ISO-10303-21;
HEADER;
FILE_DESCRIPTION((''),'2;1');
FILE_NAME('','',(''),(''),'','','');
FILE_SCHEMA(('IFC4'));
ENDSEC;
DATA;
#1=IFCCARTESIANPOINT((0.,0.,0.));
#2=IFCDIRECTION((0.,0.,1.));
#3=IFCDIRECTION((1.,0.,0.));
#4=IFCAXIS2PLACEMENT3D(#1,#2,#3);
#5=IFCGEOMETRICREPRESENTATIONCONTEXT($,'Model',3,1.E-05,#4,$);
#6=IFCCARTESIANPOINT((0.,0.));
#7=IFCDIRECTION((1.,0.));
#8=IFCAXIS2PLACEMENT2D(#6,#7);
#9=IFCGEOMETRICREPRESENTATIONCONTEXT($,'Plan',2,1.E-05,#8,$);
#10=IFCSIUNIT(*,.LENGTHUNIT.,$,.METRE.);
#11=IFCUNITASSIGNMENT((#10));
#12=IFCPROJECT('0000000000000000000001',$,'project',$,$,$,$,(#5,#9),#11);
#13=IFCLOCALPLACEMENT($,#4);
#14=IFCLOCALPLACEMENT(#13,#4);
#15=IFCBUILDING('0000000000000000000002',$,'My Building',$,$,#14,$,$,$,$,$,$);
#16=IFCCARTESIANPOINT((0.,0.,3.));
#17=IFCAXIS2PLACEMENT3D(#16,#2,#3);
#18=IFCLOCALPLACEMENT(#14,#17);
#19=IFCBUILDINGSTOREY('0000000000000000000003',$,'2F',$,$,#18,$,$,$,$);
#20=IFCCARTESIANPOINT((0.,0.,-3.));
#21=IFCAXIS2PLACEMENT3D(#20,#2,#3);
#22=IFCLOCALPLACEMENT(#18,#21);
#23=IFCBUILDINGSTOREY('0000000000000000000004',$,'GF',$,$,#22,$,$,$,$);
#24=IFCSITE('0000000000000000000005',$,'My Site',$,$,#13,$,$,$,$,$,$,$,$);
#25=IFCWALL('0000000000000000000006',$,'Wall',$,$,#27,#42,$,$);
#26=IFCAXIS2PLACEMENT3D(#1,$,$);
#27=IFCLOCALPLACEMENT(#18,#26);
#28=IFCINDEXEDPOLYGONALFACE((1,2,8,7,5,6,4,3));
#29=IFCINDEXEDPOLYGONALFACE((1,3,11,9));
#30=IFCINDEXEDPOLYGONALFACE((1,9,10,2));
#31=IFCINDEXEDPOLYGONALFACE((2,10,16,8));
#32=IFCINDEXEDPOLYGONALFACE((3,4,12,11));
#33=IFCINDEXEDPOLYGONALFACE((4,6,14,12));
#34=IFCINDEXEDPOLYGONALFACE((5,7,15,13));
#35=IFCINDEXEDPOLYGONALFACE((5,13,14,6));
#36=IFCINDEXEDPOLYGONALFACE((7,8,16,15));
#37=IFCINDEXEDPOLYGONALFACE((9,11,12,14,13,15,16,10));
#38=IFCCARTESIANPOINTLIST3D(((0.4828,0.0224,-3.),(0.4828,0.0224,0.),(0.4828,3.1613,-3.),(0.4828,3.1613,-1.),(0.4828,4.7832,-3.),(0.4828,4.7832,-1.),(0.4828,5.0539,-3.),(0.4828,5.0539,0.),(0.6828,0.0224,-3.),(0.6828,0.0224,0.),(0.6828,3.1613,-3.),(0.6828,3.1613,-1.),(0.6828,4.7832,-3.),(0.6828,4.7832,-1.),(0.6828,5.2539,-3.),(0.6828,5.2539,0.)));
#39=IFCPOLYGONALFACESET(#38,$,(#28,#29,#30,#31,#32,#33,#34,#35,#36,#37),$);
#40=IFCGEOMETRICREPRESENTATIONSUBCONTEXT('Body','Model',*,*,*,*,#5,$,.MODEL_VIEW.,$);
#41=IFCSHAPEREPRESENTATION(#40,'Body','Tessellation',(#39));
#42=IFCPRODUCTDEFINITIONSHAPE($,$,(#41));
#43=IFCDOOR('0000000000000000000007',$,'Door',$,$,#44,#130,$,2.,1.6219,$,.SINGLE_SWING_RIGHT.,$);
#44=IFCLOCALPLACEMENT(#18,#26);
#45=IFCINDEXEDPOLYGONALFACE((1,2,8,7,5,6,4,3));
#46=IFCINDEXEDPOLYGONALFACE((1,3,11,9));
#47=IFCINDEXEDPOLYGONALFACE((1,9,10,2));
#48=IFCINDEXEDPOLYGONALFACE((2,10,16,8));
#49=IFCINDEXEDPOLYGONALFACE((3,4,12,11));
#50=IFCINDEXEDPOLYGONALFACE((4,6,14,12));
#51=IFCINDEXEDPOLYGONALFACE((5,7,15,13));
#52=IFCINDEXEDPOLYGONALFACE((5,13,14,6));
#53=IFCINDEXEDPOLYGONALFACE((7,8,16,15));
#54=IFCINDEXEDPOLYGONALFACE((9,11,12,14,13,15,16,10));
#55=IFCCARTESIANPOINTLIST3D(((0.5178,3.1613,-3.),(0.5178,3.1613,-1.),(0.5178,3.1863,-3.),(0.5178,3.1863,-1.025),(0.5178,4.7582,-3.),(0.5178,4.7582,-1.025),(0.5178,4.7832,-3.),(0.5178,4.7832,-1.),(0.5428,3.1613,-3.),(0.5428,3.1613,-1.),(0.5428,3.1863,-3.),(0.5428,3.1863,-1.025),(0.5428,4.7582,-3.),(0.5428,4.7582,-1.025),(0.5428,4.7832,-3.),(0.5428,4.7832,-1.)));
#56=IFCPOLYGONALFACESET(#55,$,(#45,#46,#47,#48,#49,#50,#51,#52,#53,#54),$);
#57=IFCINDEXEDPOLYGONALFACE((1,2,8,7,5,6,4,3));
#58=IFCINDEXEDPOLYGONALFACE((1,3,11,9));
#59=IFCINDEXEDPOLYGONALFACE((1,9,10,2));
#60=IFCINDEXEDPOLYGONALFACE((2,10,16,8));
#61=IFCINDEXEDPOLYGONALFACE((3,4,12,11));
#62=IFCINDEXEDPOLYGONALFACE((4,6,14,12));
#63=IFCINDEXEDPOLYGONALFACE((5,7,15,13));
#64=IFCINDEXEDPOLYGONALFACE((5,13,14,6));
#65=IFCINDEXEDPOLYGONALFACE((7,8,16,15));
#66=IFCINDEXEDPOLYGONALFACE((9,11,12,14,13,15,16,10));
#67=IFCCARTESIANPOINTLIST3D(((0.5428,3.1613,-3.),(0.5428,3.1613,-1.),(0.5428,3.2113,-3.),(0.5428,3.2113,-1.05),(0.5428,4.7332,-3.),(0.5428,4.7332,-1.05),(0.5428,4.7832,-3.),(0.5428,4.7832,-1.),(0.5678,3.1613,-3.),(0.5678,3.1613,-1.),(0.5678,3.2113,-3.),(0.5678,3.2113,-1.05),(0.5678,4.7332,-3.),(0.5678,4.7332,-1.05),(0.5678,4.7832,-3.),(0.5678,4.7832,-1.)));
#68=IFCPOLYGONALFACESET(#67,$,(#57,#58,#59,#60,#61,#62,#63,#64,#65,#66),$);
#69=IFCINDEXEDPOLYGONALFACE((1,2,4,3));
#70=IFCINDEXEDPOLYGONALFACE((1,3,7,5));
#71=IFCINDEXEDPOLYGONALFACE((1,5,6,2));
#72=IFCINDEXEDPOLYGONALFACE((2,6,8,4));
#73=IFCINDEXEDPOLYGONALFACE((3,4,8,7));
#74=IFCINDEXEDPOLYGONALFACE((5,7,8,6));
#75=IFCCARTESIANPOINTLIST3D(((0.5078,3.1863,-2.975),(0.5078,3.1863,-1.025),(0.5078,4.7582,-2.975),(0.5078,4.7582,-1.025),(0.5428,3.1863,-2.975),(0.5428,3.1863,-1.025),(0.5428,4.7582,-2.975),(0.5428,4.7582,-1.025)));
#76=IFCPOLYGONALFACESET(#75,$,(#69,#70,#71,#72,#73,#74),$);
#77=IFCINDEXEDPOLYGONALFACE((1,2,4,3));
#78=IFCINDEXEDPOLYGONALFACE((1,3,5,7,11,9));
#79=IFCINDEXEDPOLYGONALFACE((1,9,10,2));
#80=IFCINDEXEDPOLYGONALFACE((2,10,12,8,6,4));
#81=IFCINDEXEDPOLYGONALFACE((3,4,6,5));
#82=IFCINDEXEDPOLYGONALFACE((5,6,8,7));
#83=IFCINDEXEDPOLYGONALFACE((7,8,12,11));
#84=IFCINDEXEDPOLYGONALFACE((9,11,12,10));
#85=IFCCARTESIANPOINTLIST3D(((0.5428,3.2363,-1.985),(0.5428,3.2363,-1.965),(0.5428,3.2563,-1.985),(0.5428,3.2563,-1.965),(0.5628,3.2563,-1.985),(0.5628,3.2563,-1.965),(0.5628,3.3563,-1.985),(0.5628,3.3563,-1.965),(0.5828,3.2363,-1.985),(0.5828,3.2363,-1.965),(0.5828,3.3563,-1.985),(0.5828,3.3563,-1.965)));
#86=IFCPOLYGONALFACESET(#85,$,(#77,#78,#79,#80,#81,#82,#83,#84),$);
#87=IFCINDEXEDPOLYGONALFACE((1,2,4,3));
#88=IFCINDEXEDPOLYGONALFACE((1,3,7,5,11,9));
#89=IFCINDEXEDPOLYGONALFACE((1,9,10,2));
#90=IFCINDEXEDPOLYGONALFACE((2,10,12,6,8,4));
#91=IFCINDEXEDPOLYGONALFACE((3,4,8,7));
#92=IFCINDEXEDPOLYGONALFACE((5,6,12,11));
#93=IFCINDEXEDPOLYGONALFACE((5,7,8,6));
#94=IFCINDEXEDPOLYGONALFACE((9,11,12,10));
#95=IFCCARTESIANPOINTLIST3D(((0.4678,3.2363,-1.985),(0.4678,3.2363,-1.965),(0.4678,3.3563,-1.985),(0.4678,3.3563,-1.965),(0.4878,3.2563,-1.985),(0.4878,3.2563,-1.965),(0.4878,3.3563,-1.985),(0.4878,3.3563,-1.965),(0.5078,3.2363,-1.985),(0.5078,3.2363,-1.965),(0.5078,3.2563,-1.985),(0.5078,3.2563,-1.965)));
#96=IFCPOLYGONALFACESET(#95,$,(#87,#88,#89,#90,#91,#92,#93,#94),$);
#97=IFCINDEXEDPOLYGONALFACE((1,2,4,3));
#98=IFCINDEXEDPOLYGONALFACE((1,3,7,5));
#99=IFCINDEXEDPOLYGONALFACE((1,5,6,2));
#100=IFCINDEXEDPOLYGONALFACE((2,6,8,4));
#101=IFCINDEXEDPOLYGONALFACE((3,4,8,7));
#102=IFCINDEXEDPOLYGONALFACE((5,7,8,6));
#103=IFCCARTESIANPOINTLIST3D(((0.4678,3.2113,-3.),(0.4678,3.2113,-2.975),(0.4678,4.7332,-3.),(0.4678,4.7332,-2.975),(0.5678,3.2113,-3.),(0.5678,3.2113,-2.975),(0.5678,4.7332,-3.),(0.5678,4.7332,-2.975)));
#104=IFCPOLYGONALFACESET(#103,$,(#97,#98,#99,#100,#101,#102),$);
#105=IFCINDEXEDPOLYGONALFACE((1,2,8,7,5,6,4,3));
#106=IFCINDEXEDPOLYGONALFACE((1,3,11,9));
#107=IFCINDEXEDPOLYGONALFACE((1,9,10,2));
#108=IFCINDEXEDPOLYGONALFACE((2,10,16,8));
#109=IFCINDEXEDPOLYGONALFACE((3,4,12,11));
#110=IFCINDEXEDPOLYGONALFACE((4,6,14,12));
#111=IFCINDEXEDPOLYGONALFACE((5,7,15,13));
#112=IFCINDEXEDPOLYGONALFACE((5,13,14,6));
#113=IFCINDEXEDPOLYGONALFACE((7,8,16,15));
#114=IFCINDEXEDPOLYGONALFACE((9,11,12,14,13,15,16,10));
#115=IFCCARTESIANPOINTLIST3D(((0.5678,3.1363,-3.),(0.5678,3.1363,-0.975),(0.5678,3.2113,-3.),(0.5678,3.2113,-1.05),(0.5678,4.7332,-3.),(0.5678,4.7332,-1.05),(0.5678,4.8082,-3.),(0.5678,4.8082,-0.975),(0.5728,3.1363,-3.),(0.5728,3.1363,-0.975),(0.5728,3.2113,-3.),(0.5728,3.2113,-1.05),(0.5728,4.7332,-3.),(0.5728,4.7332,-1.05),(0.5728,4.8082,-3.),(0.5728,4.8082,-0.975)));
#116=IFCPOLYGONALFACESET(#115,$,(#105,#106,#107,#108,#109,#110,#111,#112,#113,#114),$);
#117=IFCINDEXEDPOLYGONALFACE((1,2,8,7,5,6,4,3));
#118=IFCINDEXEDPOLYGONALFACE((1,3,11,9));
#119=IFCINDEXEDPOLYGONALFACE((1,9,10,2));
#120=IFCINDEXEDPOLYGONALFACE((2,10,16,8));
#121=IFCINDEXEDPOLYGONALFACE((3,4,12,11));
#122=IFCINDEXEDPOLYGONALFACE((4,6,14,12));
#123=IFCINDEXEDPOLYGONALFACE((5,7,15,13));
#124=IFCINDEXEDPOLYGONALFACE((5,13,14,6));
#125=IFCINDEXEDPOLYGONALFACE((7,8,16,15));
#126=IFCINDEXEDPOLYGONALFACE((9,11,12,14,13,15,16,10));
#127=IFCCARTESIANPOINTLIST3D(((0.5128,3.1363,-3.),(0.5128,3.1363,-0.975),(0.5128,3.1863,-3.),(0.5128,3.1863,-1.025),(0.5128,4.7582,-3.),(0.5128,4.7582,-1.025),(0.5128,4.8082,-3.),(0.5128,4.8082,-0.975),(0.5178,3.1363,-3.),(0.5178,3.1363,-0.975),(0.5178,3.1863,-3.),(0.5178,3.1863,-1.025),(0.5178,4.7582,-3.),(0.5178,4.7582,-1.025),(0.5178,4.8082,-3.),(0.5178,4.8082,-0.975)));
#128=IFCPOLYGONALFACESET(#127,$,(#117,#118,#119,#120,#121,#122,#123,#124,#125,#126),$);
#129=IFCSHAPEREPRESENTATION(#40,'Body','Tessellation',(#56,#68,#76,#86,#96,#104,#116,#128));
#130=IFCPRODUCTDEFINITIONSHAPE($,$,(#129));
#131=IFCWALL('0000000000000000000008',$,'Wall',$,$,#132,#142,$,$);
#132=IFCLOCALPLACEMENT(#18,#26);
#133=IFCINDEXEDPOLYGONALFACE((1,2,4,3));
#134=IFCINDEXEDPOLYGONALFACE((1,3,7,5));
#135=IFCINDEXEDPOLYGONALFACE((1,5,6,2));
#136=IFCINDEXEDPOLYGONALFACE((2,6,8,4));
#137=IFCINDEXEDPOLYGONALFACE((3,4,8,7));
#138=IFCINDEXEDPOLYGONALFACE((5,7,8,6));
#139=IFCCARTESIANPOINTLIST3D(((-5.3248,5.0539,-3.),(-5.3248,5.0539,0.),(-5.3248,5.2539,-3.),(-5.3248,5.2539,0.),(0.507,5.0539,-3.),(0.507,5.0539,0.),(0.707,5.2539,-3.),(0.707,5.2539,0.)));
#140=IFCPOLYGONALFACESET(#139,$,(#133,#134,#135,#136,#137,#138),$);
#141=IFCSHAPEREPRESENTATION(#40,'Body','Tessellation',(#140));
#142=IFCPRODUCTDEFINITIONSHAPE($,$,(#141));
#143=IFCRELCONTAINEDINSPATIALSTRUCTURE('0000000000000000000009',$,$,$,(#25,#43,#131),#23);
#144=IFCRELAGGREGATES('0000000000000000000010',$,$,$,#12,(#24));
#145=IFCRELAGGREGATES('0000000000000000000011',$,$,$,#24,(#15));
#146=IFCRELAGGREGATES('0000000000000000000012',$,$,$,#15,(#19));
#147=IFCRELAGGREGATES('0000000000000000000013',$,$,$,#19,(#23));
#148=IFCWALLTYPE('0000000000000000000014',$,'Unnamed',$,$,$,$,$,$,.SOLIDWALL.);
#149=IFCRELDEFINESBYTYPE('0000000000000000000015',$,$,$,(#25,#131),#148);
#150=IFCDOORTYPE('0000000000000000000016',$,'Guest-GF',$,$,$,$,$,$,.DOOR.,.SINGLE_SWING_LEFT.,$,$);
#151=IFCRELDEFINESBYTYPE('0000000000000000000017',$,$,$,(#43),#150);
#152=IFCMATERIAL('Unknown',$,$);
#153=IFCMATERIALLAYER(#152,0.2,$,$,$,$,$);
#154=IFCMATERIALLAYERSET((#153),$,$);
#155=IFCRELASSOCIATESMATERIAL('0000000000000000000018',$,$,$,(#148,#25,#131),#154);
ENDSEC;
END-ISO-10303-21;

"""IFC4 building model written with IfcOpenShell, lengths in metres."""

from ifc_helpers import new_model, entity, si_unit, frame, origin_with_axes, origin_2d_with_axis, place, context, subcontext, project, spatial, line, indexed_curve, outline, extrude, shape, source, transform, mapped, material, layer, layer_set, layer_usage, type_object, type_shapes, element, fill, save


model = new_model("IFC4")

# Units and contexts
model_context = context("Model", 3, precision=1e-05, world=origin_with_axes())
plan_context = context("Plan", 2, precision=1e-05, world=origin_2d_with_axis())
body_context_1 = subcontext(model_context, "Body", "Model", "MODEL_VIEW")
body_context_2 = subcontext(plan_context, "Body", "Plan", "PLAN_VIEW")
ifc_project = project(units=[si_unit("LENGTHUNIT", "METRE")], contexts=[model_context, plan_context])

# Site, building, storeys
site_placement = place(None, origin_with_axes())
site = spatial("IfcSite", under=ifc_project, at=site_placement, Name="My Site")
building_placement = place(site_placement, origin_with_axes())
building = spatial("IfcBuilding", under=site, at=building_placement, Name="My Building")
storey_1_placement = place(building_placement, frame((0.0, 0.0, 3.0), z_axis=(0.0, 0.0, 1.0), x_axis=(1.0, 0.0, 0.0)))
storey_1 = spatial("IfcBuildingStorey", under=building, at=storey_1_placement, Name="2F")
storey_2_placement = place(storey_1_placement, frame((0.0, 0.0, -3.0), z_axis=(0.0, 0.0, 1.0), x_axis=(1.0, 0.0, 0.0)))
storey_2 = spatial("IfcBuildingStorey", under=storey_1, at=storey_2_placement, Name="GF")

# Shared definitions
ifc_material = material(Name="Unknown")

# Shared definitions
ifc_layer_1 = layer(ifc_material, 0.2)
ifc_layer_set_1 = layer_set([ifc_layer_1])
wall_type = type_object("IfcWallType", Name="Unnamed", PredefinedType="SOLIDWALL", material=ifc_layer_set_1)

# Wall, opening, door
ifc_layer_usage_1 = layer_usage(ifc_layer_set_1, "AXIS2", "POSITIVE", 0.0)
wall_1_placement = place(storey_2_placement, frame((0.6828, -0.1776, 0.0), z_axis=(0.0, 0.0, 1.0), x_axis=(0.0, 1.0, 0.0)))
wall_1 = element("IfcWall", 1, at=wall_1_placement, inside=storey_2, type_object=wall_type, material=ifc_layer_usage_1, Name="Wall", context=body_context_1, shape_type="SweptSolid", body=[
    extrude(outline(indexed_curve([(0.2, 0.0), (0.2, 0.2), (5.2316, 0.2), (5.4316, 0.0)], segments=[line(1, 2, 3, 4, 1)])), origin_with_axes(), (0.0, 0.0, 1.0), 3.0),
])
shared_shape_1 = source(origin_with_axes(), body_context_1, "Body", "SweptSolid", [
    extrude(outline(indexed_curve([(0.0, 0.0), (1.6219, 0.0), (1.6219, 2.0), (0.0, 2.0)], segments=[line(1, 2, 3, 4, 1)])), frame((0.0, -0.6, 0.0), z_axis=(0.0, -1.0, 0.0), x_axis=(1.0, 0.0, 0.0)), (0.0, 0.0, -1.0), 1.2),
])
opening_1_placement = place(wall_1_placement, frame((3.3389, 0.115, 0.0), z_axis=(0.0, 0.0, 1.0), x_axis=(1.0, 0.0, 0.0)))
opening_1 = element("IfcOpeningElement", 2, at=opening_1_placement, cuts=wall_1, PredefinedType="OPENING", context=body_context_1, shape_type="MappedRepresentation", body=[
    mapped(shared_shape_1, transform((0.0, 0.0, 0.0), x_axis=(1.0, 0.0, 0.0), y_axis=(0.0, 1.0, 0.0), z_axis=(0.0, 0.0, 1.0), scale=1.0)),
])
door_type_1 = type_object("IfcDoorType", Name="Guest-GF", OperationType="SINGLE_SWING_LEFT", PredefinedType="DOOR")
shared_shape_2 = source(origin_with_axes(), body_context_1, "Body", "SweptSolid", [
    extrude(outline(indexed_curve([(0.0, 0.0), (0.0, 2.0), (1.6219, 2.0), (1.6219, 0.0), (1.5969, 0.0), (1.5969, 1.975), (0.025, 1.975), (0.025, 0.0)], segments=[line(1, 2, 3, 4, 5, 6, 7, 8, 1)])), frame((0.0, 0.025, 0.0), z_axis=(0.0, -1.0, 0.0), x_axis=(1.0, 0.0, 0.0)), (0.0, 0.0, -1.0), 0.025),
    extrude(outline(indexed_curve([(0.0, 0.0), (0.0, 2.0), (1.6219, 2.0), (1.6219, 0.0), (1.5719, 0.0), (1.5719, 1.95), (0.05, 1.95), (0.05, 0.0)], segments=[line(1, 2, 3, 4, 5, 6, 7, 8, 1)])), frame((0.0, 0.0, 0.0), z_axis=(0.0, -1.0, 0.0), x_axis=(1.0, 0.0, 0.0)), (0.0, 0.0, -1.0), 0.025),
    extrude(outline(indexed_curve([(0.0, 0.0), (1.5719, 0.0), (1.5719, 0.035), (0.0, 0.035)], segments=[line(1, 2, 3, 4, 1)])), frame((0.025, 0.025, 0.025), z_axis=(0.0, 0.0, 1.0), x_axis=(1.0, 0.0, 0.0)), (0.0, 0.0, 1.0), 1.95),
    extrude(outline(indexed_curve([(0.0, 0.0), (0.0, -0.04), (0.12, -0.04), (0.12, -0.02), (0.02, -0.02), (0.02, 0.0)], segments=[line(1, 2, 3, 4, 5, 6, 1)])), frame((0.075, 0.025, 1.015), z_axis=(0.0, 0.0, 1.0), x_axis=(1.0, 0.0, 0.0)), (0.0, 0.0, 1.0), 0.02),
    extrude(outline(indexed_curve([(0.0, 0.0), (0.0, 0.04), (0.12, 0.04), (0.12, 0.02), (0.02, 0.02), (0.02, 0.0)], segments=[line(1, 2, 3, 4, 5, 6, 1)])), frame((0.075, 0.06, 1.015), z_axis=(0.0, 0.0, 1.0), x_axis=(1.0, 0.0, 0.0)), (0.0, 0.0, 1.0), 0.02),
    extrude(outline(indexed_curve([(0.0, 0.0), (1.5219, 0.0), (1.5219, 0.1), (0.0, 0.1)], segments=[line(1, 2, 3, 4, 1)])), frame((0.05, 0.0, 0.0), z_axis=(0.0, 0.0, 1.0), x_axis=(1.0, 0.0, 0.0)), (0.0, 0.0, 1.0), 0.025),
    extrude(outline(indexed_curve([(0.0, 0.0), (0.0, 2.025), (1.6719, 2.025), (1.6719, 0.0), (1.5969, 0.0), (1.5969, 1.95), (0.075, 1.95), (0.075, 0.0)], segments=[line(1, 2, 3, 4, 5, 6, 7, 8, 1)])), frame((-0.025, -0.005, 0.0), z_axis=(0.0, -1.0, 0.0), x_axis=(1.0, 0.0, 0.0)), (0.0, 0.0, -1.0), 0.005),
    extrude(outline(indexed_curve([(0.0, 0.0), (0.0, 2.025), (1.6719, 2.025), (1.6719, 0.0), (1.6219, 0.0), (1.6219, 1.975), (0.05, 1.975), (0.05, 0.0)], segments=[line(1, 2, 3, 4, 5, 6, 7, 8, 1)])), frame((-0.025, 0.05, 0.0), z_axis=(0.0, -1.0, 0.0), x_axis=(1.0, 0.0, 0.0)), (0.0, 0.0, -1.0), 0.005),
])
shared_shape_3 = source(origin_with_axes(), body_context_2, "Body", "Curve2D", [
    entity("IfcIndexedPolyCurve", entity("IfcCartesianPointList2D", [[0.0, 0.0], [0.0, 0.05], [0.025, 0.05], [0.025, 0.025], [0.05, 0.025], [0.05, 0.0]]), [entity("IfcLineIndex", [1, 2, 3, 4, 5, 6, 1])]),
    entity("IfcIndexedPolyCurve", entity("IfcCartesianPointList2D", [[1.6219, 0.0], [1.6219, 0.05], [1.5969, 0.05], [1.5969, 0.025], [1.5719, 0.025], [1.5719, 0.0]]), [entity("IfcLineIndex", [1, 2, 3, 4, 5, 6, 1])]),
    entity("IfcTrimmedCurve", entity("IfcEllipse", entity("IfcAxis2Placement2D", entity("IfcCartesianPoint", [1.5619, 0.05]), entity("IfcDirection", [1.0, 0.0])), 1.5369, 1.5719), [entity("IfcCartesianPoint", [1.5619, 1.6219])], [entity("IfcCartesianPoint", [0.025, 0.05])], True, "CARTESIAN"),
    entity("IfcIndexedPolyCurve", entity("IfcCartesianPointList2D", [[1.5969, 0.05], [1.5619, 0.05], [1.5619, 1.6219], [1.5969, 1.6219]]), [entity("IfcLineIndex", [1, 2, 3, 4, 1])]),
])
type_shapes(door_type_1, [shared_shape_2, shared_shape_3])
door_1_placement = place(opening_1_placement, frame((0.0, 0.0, 0.0), z_axis=(0.0, 0.0, 1.0), x_axis=(1.0, 0.0, 0.0)))
door_1 = element("IfcDoor", 3, at=door_1_placement, inside=storey_2, type_object=door_type_1, Name="Door", OperationType="SINGLE_SWING_RIGHT", OverallHeight=2.0, OverallWidth=1.6219, shapes=[
    shape(body_context_1, "Body", "MappedRepresentation", [mapped(shared_shape_2, transform((0.0, 0.0, 0.0), x_axis=(1.0, 0.0, 0.0), y_axis=(0.0, 1.0, 0.0), z_axis=(0.0, 0.0, 1.0), scale=1.0))]),
    shape(body_context_2, "Body", "MappedRepresentation", [mapped(shared_shape_3, transform((0.0, 0.0, 0.0), x_axis=(1.0, 0.0, 0.0), y_axis=(0.0, 1.0, 0.0), z_axis=(0.0, 0.0, 1.0), scale=1.0))]),
])
fill(opening_1, door_1)

# Wall
ifc_layer_usage_2 = layer_usage(ifc_layer_set_1, "AXIS2", "POSITIVE", 0.0)
wall_2_placement = place(storey_2_placement, frame((-5.5248, 5.0539, 0.0), z_axis=(0.0, 0.0, 1.0), x_axis=(1.0, 0.0, 0.0)))
element("IfcWall", 4, at=wall_2_placement, inside=storey_2, type_object=wall_type, material=ifc_layer_usage_2, Name="Wall", context=body_context_1, shape_type="SweptSolid", body=[
    extrude(outline(indexed_curve([(0.2, 0.0), (0.2, 0.2), (6.2318, 0.2), (6.0318, 0.0)], segments=[line(1, 2, 3, 4, 1)])), origin_with_axes(), (0.0, 0.0, 1.0), 3.0),
])

save(model, "model.ifc")
